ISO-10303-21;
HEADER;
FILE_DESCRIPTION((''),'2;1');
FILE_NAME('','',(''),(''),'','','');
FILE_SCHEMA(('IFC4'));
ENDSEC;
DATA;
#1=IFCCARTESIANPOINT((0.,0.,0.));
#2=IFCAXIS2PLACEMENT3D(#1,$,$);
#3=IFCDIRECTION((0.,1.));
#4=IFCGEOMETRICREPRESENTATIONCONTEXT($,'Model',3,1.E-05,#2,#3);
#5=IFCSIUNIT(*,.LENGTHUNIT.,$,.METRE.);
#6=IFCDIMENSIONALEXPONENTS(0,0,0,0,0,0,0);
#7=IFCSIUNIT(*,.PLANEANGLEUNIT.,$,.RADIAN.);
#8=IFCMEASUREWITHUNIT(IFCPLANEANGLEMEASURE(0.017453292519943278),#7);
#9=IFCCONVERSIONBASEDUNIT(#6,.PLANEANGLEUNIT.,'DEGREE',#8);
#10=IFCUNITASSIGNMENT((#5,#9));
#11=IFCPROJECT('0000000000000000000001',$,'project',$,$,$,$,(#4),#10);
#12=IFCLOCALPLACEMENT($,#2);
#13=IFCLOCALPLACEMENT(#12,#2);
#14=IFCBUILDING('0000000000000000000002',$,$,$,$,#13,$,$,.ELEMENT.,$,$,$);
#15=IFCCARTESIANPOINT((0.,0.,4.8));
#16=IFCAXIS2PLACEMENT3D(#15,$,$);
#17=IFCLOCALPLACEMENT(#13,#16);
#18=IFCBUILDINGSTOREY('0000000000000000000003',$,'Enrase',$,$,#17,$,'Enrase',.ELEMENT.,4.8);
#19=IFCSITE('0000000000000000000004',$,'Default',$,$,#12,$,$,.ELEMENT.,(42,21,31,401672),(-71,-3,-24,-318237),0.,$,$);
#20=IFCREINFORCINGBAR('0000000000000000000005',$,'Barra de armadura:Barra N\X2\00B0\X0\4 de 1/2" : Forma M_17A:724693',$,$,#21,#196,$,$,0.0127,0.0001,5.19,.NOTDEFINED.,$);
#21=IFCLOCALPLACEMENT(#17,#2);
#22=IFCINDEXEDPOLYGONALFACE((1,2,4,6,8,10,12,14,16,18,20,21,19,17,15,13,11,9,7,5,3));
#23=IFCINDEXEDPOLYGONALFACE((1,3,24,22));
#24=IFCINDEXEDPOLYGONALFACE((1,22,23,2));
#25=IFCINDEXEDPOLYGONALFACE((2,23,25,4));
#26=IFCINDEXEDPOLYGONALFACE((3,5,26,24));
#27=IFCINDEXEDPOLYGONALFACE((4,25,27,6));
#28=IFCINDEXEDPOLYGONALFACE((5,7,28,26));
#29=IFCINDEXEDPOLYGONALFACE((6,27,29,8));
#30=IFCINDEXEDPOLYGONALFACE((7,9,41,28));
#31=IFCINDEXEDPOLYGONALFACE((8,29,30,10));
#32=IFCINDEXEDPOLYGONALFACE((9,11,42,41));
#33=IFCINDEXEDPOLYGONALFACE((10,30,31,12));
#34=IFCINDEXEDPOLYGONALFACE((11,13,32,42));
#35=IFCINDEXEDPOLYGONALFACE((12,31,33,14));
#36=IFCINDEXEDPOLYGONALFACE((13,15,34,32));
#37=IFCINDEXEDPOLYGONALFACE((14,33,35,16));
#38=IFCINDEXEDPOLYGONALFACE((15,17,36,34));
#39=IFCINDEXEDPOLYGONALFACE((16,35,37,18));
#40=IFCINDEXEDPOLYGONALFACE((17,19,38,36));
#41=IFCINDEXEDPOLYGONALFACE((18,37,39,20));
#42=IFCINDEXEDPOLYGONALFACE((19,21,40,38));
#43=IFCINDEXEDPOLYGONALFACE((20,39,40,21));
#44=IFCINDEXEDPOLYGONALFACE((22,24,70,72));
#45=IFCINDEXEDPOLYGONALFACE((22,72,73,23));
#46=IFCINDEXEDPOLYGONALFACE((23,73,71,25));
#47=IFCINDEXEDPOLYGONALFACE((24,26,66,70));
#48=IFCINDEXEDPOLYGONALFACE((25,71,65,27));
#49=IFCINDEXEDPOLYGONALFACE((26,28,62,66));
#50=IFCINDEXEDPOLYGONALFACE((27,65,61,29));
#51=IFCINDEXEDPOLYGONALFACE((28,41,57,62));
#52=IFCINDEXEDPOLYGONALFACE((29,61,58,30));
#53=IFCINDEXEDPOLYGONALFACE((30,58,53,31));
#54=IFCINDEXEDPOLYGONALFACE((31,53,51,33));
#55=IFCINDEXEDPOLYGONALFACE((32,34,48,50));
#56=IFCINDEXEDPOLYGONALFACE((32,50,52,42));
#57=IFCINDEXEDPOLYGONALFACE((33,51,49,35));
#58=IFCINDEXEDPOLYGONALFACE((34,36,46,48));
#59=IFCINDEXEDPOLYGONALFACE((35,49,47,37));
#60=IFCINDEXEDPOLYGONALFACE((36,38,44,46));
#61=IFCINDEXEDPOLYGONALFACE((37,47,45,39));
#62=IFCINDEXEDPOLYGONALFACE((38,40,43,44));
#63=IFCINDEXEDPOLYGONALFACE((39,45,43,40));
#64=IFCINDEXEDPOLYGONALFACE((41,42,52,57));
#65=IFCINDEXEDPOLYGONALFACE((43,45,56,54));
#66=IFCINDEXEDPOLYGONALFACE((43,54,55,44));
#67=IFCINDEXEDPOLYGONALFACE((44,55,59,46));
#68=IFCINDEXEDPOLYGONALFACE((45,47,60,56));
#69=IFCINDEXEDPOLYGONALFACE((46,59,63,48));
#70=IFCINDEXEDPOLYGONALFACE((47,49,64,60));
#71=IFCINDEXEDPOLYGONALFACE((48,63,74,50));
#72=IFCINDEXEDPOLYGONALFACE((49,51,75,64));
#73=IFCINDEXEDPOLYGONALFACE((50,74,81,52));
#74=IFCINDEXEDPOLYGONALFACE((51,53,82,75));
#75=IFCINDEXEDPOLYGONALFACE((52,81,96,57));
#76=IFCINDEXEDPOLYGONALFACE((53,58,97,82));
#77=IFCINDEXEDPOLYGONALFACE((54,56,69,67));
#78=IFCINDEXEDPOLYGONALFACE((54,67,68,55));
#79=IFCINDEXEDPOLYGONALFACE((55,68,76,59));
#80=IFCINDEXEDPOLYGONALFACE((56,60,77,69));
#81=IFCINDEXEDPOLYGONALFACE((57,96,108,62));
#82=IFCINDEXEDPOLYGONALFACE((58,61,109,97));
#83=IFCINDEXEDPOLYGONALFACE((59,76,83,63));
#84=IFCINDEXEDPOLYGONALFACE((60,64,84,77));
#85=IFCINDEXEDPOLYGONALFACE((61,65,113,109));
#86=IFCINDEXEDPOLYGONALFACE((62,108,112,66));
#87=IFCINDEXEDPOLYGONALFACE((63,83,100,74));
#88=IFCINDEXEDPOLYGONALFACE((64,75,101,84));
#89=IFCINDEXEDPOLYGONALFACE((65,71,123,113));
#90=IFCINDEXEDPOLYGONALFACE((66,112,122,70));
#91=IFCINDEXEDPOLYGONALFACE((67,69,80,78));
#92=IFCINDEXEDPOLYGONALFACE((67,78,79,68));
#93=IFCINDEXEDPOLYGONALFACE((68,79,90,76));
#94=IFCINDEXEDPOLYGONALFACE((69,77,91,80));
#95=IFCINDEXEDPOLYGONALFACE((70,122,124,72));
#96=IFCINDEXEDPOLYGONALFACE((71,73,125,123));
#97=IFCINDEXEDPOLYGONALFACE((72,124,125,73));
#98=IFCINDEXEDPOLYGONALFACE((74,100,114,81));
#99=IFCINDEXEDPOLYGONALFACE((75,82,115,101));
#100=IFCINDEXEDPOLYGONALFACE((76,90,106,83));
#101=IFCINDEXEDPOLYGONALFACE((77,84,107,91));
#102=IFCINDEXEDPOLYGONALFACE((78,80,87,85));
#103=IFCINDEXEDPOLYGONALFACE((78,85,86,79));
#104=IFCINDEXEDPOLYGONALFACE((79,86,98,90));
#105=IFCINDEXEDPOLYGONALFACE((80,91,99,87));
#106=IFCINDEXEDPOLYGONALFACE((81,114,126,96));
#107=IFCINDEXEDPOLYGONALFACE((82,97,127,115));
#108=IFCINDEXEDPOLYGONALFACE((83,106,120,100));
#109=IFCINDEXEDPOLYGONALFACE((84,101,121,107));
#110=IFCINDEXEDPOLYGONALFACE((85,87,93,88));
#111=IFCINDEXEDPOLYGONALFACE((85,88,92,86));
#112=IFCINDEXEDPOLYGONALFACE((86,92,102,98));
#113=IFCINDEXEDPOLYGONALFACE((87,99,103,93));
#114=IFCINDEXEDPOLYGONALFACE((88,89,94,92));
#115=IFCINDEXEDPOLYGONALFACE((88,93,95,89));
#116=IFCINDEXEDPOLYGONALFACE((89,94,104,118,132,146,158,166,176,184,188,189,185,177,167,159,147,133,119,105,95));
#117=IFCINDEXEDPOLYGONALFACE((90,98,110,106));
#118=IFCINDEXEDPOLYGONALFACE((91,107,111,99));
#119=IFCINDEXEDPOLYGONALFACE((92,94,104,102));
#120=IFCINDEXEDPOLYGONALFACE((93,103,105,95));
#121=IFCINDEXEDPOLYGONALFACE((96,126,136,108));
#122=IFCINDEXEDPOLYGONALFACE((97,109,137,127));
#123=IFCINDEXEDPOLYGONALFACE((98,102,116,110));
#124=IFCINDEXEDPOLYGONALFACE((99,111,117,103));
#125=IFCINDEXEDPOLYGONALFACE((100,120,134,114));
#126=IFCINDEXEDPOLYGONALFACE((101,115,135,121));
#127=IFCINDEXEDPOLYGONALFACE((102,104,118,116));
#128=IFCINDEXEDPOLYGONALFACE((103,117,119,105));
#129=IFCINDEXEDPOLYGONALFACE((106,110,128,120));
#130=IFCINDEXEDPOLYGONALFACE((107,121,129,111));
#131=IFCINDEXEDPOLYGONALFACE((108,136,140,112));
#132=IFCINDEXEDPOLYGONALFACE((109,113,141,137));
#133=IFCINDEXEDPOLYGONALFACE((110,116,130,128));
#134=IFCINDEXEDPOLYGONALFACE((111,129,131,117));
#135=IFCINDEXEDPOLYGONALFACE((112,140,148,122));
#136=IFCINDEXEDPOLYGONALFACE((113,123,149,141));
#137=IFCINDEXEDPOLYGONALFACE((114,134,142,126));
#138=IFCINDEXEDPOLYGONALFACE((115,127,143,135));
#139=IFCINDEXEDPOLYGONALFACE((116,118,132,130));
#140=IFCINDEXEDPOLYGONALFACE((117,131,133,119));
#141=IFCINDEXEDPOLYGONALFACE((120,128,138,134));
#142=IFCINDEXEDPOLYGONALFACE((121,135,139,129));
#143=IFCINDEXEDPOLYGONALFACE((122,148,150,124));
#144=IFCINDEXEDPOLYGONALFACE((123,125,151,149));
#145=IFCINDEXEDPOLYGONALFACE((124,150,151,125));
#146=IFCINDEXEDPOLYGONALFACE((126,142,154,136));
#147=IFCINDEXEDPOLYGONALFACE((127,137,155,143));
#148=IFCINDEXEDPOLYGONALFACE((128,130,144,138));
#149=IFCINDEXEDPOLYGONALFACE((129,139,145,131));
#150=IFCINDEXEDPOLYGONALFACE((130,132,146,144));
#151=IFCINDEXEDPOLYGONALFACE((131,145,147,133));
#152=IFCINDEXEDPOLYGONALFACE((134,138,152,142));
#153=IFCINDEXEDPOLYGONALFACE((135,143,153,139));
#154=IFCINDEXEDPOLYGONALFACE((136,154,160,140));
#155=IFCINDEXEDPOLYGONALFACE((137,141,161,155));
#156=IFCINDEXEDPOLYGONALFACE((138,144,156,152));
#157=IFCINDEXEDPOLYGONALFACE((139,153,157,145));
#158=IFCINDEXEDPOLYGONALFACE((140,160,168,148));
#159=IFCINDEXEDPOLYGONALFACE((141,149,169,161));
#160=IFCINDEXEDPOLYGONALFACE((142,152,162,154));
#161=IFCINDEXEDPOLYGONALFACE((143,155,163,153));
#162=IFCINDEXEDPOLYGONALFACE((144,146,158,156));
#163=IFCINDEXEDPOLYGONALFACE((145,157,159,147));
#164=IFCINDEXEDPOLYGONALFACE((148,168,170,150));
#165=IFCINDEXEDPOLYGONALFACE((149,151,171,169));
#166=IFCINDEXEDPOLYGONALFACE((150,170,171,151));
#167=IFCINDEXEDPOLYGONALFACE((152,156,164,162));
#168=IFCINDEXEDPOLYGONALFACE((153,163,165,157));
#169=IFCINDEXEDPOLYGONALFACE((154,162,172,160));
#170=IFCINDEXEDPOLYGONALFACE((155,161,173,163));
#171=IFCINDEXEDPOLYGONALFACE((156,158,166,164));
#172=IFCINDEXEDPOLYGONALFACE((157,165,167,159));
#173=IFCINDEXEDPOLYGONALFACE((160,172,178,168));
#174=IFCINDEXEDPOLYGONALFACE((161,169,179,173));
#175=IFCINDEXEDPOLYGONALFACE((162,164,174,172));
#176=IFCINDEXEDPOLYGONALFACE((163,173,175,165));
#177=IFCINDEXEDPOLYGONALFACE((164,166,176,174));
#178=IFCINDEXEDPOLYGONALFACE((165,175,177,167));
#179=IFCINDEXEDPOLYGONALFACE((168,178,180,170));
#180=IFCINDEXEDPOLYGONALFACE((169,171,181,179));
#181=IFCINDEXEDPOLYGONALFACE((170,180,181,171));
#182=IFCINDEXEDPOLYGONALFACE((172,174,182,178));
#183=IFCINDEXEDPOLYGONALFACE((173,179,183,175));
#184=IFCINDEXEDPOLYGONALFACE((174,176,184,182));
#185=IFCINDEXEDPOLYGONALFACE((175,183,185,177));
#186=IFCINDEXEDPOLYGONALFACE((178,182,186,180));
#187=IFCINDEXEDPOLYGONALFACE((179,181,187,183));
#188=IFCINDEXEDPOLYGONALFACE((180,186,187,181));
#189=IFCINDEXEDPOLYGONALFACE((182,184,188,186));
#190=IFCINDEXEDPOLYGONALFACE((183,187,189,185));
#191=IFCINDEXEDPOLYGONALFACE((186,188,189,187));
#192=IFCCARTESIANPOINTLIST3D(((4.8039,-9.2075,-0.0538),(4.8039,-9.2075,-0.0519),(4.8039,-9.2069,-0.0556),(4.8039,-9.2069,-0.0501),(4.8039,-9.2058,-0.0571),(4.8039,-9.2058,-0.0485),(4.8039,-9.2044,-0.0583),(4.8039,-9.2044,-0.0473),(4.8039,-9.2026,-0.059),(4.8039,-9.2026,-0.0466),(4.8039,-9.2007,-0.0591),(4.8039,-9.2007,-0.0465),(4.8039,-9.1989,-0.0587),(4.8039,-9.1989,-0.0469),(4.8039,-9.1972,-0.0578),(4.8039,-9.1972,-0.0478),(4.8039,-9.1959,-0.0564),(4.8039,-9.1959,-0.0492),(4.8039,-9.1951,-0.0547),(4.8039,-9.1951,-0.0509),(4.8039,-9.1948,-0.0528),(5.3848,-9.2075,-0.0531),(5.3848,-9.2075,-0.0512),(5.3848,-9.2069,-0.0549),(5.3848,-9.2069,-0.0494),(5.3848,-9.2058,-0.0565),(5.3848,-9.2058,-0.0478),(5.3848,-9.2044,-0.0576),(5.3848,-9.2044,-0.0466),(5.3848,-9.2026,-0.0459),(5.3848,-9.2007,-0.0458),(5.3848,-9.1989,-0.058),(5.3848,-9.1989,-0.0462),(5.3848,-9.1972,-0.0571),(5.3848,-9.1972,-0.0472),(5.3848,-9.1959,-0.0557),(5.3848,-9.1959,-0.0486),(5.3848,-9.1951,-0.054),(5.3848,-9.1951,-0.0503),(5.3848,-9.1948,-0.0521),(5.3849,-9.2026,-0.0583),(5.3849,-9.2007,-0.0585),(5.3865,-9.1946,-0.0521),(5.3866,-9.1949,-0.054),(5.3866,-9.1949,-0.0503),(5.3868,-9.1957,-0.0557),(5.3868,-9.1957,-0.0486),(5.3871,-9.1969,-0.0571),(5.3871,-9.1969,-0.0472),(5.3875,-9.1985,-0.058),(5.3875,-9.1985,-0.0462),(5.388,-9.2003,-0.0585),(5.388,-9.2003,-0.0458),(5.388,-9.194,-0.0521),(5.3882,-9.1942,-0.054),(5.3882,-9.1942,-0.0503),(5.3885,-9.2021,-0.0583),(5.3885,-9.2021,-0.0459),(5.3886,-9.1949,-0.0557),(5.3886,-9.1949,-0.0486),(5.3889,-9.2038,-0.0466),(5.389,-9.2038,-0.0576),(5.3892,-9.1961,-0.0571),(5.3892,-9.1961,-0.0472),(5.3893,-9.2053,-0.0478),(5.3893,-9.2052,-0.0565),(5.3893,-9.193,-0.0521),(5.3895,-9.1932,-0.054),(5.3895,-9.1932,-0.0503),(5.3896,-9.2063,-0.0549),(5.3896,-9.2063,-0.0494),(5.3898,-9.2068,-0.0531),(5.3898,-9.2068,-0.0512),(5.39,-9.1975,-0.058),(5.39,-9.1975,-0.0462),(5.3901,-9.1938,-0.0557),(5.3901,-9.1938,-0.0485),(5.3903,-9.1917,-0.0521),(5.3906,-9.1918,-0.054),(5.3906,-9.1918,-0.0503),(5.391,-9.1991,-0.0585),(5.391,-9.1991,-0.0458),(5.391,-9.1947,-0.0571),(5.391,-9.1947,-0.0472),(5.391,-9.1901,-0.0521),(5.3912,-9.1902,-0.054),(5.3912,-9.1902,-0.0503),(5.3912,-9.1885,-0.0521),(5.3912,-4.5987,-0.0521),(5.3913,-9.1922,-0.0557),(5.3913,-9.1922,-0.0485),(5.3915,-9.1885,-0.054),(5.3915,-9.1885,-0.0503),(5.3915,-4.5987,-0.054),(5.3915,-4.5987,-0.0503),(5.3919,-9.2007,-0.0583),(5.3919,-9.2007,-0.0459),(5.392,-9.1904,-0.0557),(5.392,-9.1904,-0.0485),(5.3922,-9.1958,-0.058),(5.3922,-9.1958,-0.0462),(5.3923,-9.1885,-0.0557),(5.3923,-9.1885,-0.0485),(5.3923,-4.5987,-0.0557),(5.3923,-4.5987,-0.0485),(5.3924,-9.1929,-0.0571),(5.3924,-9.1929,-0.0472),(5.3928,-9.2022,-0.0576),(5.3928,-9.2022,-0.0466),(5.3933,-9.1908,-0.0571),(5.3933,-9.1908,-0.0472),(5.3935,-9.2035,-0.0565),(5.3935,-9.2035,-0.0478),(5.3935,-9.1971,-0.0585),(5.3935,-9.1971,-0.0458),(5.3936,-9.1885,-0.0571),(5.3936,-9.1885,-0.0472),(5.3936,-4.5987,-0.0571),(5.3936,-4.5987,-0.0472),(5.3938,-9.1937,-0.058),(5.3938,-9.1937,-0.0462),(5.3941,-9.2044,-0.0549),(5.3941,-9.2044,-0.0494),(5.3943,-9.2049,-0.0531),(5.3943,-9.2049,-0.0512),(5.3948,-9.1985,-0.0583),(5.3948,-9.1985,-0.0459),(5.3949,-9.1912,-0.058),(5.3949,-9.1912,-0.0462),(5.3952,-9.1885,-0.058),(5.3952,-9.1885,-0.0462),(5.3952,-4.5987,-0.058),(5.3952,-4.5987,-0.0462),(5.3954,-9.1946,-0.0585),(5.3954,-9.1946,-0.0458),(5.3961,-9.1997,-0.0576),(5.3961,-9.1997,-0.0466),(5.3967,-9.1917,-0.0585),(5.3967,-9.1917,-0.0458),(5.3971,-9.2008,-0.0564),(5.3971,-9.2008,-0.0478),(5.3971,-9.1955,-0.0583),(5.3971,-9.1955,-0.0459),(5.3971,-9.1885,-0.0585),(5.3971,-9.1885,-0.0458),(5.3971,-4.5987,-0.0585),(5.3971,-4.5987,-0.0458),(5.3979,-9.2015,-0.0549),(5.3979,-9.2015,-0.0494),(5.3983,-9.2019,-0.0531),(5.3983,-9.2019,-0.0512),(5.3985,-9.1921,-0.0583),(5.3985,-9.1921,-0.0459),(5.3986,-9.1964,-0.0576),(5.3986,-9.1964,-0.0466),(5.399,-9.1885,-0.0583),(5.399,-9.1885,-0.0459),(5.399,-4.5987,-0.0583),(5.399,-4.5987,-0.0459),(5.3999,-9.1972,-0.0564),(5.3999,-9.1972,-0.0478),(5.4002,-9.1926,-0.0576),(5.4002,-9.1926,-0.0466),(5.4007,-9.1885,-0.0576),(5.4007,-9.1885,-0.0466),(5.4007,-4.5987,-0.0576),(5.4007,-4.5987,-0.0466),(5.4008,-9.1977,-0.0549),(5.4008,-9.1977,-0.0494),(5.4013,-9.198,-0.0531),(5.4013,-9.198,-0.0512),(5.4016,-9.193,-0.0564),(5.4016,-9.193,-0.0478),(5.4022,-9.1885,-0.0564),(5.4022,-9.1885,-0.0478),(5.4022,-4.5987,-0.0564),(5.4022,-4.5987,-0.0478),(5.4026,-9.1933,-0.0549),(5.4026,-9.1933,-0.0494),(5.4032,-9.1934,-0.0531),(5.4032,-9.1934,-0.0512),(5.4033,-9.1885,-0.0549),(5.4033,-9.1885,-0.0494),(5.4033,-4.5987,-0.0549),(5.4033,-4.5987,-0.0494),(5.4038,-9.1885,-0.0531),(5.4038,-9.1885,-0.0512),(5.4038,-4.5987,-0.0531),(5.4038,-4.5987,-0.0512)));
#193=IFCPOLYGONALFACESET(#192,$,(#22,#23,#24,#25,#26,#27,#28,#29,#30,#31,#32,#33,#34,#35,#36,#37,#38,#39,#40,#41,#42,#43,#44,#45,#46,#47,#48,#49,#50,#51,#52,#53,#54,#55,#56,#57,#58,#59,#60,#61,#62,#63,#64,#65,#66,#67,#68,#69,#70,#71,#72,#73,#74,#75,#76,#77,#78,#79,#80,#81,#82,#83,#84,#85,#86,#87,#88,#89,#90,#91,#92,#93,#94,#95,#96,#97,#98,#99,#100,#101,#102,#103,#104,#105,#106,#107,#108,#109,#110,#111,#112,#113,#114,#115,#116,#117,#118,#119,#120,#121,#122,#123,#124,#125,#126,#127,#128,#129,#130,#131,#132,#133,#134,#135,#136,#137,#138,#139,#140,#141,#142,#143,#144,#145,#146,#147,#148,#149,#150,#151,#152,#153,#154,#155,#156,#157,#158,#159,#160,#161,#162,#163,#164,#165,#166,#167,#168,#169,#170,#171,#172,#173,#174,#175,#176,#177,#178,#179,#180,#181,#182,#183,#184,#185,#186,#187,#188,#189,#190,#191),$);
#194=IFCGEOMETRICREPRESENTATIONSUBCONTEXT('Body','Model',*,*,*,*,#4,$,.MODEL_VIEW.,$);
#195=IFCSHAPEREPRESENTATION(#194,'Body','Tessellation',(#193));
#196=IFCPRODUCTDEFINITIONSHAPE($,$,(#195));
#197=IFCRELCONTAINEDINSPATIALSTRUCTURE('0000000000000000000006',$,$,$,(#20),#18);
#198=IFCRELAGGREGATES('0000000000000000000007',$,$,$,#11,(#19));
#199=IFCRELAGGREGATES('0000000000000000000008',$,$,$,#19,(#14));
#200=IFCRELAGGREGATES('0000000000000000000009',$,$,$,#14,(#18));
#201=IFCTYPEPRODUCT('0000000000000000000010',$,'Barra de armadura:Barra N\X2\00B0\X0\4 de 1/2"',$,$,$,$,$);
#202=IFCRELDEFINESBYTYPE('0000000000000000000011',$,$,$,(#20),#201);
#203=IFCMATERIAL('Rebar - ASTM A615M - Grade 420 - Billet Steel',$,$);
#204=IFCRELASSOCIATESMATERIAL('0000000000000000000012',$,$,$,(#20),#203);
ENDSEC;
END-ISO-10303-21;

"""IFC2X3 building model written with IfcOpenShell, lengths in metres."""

from ifc_helpers import new_model, entity, si_unit, converted_unit, direction, frame, origin, place, context, subcontext, project, spatial, material, type_object, element, save


model = new_model("IFC2X3")

# Units and contexts
model_context = context("Model", 3, precision=1e-05, world=origin(), true_north=direction((0.0, 1.0)))
body_context = subcontext(model_context, "Body", "Model", "MODEL_VIEW")
ifc_project = project(units=[si_unit("LENGTHUNIT", "METRE"), converted_unit("PLANEANGLEUNIT", "DEGREE", entity("IfcPlaneAngleMeasure", 0.017453292519943278), si_unit("PLANEANGLEUNIT", "RADIAN"), dimensions=[0, 0, 0, 0, 0, 0, 0])], contexts=[model_context])

# Site, building, storey
site_placement = place(None, origin())
site = spatial("IfcSite", under=ifc_project, at=site_placement, Name="Default", CompositionType="ELEMENT", RefLatitude=(42, 21, 31, 401672), RefLongitude=(-71, -3, -24, -318237), RefElevation=0.0)
building_placement = place(site_placement, origin())
building = spatial("IfcBuilding", under=site, at=building_placement, CompositionType="ELEMENT")
storey_placement = place(building_placement, frame((0.0, 0.0, 4.8)))
storey = spatial("IfcBuildingStorey", under=building, at=storey_placement, Name="Enrase", LongName="Enrase", CompositionType="ELEMENT", Elevation=4.8)

# Reinforcing bar
ifc_material = material(Name="Rebar - ASTM A615M - Grade 420 - Billet Steel")
type_product_1 = type_object("IfcTypeProduct", Name="Barra de armadura:Barra N°4 de 1/2\"")
reinforcing_bar_1_placement = place(storey_placement, origin())
element("IfcReinforcingBar", 1, at=reinforcing_bar_1_placement, inside=storey, type_object=type_product_1, material=ifc_material, Name="Barra de armadura:Barra N°4 de 1/2\" : Forma M_17A:724693", BarLength=5.19, BarRole="NOTDEFINED", CrossSectionArea=0.0001, NominalDiameter=0.0127, context=body_context, shape_type="AdvancedSweptSolid", body=[
    entity("IfcSweptDiskSolid", entity("IfcCompositeCurve", [entity("IfcCompositeCurveSegment", "CONTINUOUS", True, entity("IfcPolyline", [entity("IfcCartesianPoint", [5.3975, -4.5987, -0.0521]), entity("IfcCartesianPoint", [5.3975, -9.1885, -0.0521])])), entity("IfcCompositeCurveSegment", "CONTINUOUS", True, entity("IfcTrimmedCurve", entity("IfcCircle", entity("IfcAxis2Placement3D", entity("IfcCartesianPoint", [5.3848, -9.1885, -0.0521]), entity("IfcDirection", [0.001144, 0.0, -0.999999]), entity("IfcDirection", [0.0, -1.0, 0.0])), 0.0127), [entity("IfcParameterValue", 270.0)], [entity("IfcParameterValue", 360.0)], True, "PARAMETER")), entity("IfcCompositeCurveSegment", "CONTINUOUS", True, entity("IfcPolyline", [entity("IfcCartesianPoint", [5.3848, -9.2012, -0.0521]), entity("IfcCartesianPoint", [4.8039, -9.2012, -0.0528])]))], False), 0.0063, None, 0.0, 92.0),
])

save(model, "model.ifc")
